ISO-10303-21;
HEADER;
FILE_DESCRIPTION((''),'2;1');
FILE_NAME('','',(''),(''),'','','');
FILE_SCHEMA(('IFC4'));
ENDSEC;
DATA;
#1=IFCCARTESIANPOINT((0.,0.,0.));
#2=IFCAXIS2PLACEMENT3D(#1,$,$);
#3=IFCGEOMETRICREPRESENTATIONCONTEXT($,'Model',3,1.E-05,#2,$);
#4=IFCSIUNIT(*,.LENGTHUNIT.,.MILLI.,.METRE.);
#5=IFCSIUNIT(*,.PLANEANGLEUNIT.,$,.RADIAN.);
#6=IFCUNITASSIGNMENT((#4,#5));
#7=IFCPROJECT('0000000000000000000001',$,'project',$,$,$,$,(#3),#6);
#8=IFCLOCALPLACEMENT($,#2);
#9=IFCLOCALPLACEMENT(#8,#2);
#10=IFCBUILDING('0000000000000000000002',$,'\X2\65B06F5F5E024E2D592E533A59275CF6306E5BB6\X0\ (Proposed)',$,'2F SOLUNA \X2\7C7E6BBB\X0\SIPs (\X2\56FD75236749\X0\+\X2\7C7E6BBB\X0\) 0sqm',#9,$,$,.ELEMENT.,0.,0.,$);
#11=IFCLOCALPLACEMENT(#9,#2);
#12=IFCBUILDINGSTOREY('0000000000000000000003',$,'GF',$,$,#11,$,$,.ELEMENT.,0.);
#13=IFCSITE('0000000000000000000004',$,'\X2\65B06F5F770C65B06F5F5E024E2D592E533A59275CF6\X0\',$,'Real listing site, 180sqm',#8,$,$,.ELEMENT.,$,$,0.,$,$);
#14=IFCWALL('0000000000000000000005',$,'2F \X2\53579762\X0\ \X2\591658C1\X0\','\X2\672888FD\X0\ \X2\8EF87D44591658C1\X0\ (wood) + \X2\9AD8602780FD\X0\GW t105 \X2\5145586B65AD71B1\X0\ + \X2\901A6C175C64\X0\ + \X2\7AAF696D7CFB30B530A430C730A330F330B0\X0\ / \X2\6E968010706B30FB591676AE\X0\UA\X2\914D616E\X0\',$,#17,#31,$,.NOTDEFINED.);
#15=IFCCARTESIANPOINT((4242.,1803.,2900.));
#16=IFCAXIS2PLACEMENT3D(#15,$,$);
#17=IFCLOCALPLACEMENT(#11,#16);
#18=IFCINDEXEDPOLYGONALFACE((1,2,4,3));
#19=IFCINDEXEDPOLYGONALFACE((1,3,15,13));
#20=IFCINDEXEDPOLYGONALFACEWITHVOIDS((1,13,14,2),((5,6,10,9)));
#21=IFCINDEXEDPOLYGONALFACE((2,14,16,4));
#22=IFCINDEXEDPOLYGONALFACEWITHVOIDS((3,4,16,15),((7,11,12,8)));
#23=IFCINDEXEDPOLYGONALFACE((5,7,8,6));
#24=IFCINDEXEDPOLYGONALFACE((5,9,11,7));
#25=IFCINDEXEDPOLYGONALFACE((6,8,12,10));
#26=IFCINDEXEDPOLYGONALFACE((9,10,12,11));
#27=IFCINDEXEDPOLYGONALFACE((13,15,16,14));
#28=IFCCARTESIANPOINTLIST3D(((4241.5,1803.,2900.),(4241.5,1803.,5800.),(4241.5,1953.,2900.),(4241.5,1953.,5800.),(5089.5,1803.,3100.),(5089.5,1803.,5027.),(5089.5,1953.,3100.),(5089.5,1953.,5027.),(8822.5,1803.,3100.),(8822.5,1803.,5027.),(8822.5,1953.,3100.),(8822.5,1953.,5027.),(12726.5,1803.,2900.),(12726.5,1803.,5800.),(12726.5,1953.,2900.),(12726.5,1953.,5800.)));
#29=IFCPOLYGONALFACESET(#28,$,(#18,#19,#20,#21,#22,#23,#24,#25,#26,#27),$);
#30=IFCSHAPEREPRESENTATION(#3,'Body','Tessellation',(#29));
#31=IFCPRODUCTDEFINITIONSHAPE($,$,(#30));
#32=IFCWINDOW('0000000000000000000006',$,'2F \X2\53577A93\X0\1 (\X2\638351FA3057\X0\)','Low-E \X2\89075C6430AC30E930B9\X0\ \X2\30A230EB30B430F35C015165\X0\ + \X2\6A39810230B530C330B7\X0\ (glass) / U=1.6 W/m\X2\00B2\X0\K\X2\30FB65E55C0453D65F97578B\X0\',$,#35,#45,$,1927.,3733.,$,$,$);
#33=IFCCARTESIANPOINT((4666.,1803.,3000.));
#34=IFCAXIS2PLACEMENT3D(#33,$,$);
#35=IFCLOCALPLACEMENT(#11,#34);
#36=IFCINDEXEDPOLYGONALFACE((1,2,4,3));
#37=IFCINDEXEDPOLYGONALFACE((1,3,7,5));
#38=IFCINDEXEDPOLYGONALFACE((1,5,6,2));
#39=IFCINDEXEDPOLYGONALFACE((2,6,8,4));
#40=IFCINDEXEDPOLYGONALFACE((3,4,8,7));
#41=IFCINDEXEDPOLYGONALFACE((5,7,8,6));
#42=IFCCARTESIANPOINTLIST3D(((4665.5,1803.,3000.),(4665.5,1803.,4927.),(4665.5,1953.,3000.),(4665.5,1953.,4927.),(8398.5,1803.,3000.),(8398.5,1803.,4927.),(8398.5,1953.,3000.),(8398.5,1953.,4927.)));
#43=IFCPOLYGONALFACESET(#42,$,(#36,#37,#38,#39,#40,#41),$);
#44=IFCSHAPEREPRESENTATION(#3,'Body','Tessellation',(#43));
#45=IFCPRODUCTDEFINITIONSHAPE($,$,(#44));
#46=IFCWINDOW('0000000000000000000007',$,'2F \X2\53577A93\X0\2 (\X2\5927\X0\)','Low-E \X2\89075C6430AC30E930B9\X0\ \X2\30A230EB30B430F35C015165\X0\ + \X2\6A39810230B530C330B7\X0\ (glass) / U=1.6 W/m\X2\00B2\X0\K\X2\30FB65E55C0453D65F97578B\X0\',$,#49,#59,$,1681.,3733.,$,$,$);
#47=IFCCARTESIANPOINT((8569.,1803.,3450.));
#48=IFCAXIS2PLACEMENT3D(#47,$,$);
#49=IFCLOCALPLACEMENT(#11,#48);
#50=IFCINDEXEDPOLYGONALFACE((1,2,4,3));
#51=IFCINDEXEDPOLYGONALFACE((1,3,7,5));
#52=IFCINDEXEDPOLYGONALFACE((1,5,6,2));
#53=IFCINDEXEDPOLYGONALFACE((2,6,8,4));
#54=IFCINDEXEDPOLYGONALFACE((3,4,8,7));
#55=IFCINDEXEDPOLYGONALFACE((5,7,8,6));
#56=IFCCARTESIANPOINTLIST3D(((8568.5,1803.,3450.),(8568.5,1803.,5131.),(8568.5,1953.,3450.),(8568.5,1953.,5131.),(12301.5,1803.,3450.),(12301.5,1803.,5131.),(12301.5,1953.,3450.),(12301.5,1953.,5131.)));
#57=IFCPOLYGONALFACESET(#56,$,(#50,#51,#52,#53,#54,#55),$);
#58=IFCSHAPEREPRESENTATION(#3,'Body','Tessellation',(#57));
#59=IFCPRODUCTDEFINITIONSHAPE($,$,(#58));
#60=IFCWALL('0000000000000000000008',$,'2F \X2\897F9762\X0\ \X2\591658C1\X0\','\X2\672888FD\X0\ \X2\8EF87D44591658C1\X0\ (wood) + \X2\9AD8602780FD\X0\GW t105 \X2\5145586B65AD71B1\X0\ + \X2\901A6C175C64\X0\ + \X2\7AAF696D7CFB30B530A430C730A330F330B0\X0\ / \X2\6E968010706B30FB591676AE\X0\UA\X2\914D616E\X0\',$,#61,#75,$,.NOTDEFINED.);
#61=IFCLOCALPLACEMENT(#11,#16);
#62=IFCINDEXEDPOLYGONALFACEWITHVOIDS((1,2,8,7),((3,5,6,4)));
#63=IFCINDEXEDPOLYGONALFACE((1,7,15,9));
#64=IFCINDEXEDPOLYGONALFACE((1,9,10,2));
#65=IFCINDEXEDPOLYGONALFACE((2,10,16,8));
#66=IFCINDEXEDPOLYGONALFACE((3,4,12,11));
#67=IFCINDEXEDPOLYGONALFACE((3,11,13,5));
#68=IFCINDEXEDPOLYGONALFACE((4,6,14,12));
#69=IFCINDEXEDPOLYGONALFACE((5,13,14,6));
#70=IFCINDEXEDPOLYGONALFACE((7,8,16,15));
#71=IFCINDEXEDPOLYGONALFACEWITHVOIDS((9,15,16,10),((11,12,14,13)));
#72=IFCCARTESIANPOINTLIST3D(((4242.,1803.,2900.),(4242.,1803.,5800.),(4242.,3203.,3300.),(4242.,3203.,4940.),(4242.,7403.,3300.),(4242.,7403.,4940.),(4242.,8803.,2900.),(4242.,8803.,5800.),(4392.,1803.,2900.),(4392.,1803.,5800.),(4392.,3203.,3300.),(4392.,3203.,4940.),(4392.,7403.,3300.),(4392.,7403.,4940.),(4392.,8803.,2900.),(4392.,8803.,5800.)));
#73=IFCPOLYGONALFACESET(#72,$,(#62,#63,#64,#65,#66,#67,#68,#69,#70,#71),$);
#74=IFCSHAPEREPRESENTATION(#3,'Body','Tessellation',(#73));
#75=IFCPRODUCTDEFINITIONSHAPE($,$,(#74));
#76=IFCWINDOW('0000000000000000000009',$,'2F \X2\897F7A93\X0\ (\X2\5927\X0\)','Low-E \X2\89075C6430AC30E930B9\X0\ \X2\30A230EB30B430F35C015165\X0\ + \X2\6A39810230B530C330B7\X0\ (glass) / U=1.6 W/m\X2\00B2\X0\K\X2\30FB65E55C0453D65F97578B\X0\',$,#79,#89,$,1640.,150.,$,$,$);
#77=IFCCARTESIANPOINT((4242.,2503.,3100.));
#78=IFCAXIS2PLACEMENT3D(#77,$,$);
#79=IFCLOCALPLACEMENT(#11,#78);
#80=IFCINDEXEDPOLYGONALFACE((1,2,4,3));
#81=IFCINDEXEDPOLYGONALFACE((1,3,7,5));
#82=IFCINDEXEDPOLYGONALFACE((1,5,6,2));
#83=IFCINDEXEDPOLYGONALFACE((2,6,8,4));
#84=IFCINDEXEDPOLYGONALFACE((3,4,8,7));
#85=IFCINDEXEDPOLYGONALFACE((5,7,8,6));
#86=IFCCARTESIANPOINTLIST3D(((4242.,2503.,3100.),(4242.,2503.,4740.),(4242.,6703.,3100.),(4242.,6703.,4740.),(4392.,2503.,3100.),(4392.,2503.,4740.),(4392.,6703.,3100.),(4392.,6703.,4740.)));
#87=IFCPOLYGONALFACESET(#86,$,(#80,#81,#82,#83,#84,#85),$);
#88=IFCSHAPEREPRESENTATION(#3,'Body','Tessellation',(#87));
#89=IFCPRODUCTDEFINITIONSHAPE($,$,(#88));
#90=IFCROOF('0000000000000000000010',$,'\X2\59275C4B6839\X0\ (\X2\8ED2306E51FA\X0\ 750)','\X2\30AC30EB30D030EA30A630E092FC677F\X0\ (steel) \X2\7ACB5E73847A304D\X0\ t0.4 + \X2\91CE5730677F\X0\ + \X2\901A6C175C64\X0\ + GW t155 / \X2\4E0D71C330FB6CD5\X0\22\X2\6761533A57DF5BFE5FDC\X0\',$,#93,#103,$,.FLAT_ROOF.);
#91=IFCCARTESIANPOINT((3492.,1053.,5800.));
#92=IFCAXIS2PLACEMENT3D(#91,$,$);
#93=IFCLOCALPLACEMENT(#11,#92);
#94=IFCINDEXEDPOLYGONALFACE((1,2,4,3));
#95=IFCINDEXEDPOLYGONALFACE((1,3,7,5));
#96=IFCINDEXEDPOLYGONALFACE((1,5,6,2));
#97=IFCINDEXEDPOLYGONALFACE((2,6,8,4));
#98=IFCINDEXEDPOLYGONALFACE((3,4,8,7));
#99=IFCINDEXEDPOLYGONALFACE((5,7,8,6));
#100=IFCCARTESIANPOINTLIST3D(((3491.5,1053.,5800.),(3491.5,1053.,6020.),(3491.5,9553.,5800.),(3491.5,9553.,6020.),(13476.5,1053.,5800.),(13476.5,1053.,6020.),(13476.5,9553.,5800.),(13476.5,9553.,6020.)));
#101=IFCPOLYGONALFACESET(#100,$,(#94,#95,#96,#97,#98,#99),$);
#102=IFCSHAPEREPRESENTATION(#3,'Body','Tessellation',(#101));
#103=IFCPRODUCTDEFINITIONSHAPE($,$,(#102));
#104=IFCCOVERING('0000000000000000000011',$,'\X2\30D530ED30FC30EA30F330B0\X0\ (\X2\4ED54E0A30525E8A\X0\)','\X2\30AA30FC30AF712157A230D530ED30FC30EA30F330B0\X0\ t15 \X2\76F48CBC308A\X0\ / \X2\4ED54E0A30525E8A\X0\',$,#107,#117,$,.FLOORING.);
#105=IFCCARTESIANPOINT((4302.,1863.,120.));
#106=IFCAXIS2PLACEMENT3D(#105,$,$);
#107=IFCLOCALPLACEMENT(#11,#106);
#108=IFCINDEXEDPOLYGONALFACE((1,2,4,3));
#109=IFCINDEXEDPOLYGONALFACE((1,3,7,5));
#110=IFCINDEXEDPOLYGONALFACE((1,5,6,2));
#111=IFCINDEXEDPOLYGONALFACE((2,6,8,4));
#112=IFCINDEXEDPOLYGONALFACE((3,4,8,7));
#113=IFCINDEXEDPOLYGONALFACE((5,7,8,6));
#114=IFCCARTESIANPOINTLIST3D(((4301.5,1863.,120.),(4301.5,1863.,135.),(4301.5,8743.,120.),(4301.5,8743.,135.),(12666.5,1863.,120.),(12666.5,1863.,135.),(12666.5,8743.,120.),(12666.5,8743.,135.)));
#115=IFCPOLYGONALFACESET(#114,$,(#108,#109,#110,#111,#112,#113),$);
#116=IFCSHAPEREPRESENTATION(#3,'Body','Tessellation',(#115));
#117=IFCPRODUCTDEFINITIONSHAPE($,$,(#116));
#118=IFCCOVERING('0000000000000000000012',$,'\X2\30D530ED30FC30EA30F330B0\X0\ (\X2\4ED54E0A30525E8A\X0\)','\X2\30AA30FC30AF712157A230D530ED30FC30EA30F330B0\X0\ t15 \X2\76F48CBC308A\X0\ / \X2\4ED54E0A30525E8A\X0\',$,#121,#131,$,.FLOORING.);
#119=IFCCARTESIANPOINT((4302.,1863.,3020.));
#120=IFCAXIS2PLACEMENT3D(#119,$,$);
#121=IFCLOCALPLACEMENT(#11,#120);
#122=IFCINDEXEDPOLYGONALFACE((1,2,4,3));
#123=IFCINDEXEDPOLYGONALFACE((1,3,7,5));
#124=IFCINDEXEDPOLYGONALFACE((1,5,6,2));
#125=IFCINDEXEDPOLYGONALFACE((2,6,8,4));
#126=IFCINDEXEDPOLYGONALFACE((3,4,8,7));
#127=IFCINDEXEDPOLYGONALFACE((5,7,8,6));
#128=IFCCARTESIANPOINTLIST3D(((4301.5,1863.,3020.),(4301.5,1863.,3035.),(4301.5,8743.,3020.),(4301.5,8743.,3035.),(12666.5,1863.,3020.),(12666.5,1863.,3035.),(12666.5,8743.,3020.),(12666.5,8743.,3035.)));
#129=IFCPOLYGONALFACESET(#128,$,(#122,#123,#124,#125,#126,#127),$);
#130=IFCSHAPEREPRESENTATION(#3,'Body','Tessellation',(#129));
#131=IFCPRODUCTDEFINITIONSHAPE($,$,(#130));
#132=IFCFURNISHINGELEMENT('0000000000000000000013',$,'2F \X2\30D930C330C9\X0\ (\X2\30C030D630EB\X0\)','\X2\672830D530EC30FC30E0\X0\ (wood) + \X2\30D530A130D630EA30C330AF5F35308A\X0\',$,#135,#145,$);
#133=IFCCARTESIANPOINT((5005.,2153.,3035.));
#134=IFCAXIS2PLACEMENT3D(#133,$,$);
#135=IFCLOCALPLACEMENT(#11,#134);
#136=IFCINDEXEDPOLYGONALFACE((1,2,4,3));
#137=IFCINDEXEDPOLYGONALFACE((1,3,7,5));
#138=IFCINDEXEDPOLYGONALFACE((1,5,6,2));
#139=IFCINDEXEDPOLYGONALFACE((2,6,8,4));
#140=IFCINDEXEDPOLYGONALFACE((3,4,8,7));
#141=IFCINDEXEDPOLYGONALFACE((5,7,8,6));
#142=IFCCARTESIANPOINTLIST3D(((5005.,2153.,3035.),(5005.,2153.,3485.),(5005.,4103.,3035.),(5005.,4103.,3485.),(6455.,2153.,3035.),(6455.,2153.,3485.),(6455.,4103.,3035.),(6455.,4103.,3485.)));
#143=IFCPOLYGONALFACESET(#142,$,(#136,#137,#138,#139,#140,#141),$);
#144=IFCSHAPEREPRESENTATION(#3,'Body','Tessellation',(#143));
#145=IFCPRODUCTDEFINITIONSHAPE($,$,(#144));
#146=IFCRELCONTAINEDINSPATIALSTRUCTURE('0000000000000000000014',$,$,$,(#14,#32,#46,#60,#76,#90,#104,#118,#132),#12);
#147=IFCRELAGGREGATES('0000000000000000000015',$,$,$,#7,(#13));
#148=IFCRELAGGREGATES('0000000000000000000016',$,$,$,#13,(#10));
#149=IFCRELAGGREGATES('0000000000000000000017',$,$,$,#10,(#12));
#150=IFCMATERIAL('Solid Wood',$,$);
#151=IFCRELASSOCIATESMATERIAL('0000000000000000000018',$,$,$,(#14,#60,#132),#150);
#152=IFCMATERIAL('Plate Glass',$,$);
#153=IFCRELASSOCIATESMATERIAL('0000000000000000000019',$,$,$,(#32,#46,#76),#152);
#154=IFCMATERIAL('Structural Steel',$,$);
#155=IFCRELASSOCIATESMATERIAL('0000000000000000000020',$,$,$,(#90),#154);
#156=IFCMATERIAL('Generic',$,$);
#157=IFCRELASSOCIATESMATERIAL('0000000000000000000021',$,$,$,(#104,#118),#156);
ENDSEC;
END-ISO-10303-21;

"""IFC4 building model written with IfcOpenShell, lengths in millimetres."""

from ifc_helpers import new_model, si_unit, frame, frame_2d, origin, place, context, project, spatial, rectangle, extrude, material, element, fill, save


model = new_model("IFC4")

# Units and contexts
model_context = context("Model", 3, precision=1e-05, world=origin())
ifc_project = project(units=[si_unit("LENGTHUNIT", "METRE", prefix="MILLI"), si_unit("PLANEANGLEUNIT", "RADIAN")], contexts=[model_context])

# Site, building, storey
site_placement = place(None, origin())
site = spatial("IfcSite", under=ifc_project, at=site_placement, Name="新潟県新潟市中央区大島", ObjectType="Real listing site, 180sqm", CompositionType="ELEMENT", RefElevation=0.0)
building_placement = place(site_placement, origin())
building = spatial("IfcBuilding", under=site, at=building_placement, Name="新潟市中央区大島の家 (Proposed)", ObjectType="2F SOLUNA 籾殻SIPs (国産杉+籾殻) 0sqm", CompositionType="ELEMENT", ElevationOfRefHeight=0.0, ElevationOfTerrain=0.0)
storey_placement = place(building_placement, origin())
storey = spatial("IfcBuildingStorey", under=building, at=storey_placement, Name="GF", CompositionType="ELEMENT", Elevation=0.0)

# Shared definitions
ifc_material_1 = material(Name="Solid Wood")

# Shared definitions
ifc_material_2 = material(Name="Plate Glass")

# Wall, openings, windows
wall_1_placement = place(storey_placement, frame((4242.0, 1803.0, 2900.0)))
wall_1 = element("IfcWall", 1, at=wall_1_placement, inside=storey, material=ifc_material_1, Name="2F 南面 外壁", Description="木製 軸組外壁 (wood) + 高性能GW t105 充填断熱 + 通気層 + 窯業系サイディング / 準耐火・外皮UA配慮", PredefinedType="NOTDEFINED", context=model_context, shape_type="SweptSolid", body=[
    extrude(rectangle(XDim=8485.0, YDim=150.0, at=frame_2d((4242.0, 75.0))), frame((4242.0, 1803.0, 2900.0)), (0.0, 0.0, 1.0), 2900.0),
])
opening_1_placement = place(storey_placement, frame((4666.0, 1803.0, 3000.0)))
opening_1 = element("IfcOpeningElement", 2, at=opening_1_placement, cuts=wall_1, PredefinedType="NOTDEFINED", context=model_context, shape_type="SweptSolid", body=[
    extrude(rectangle(XDim=3733.0, YDim=150.0, at=frame_2d((1866.0, 75.0))), frame((4666.0, 1803.0, 3000.0)), (0.0, 0.0, 1.0), 1927.0),
])
opening_2_placement = place(storey_placement, frame((8569.0, 1803.0, 3450.0)))
opening_2 = element("IfcOpeningElement", 3, at=opening_2_placement, cuts=wall_1, PredefinedType="NOTDEFINED", context=model_context, shape_type="SweptSolid", body=[
    extrude(rectangle(XDim=3733.0, YDim=150.0, at=frame_2d((1866.0, 75.0))), frame((8569.0, 1803.0, 3450.0)), (0.0, 0.0, 1.0), 1681.0),
])
window_1_placement = place(storey_placement, frame((4666.0, 1803.0, 3000.0)))
window_1 = element("IfcWindow", 4, at=window_1_placement, inside=storey, material=ifc_material_2, Name="2F 南窓1 (掃出し)", Description="Low-E 複層ガラス アルゴン封入 + 樹脂サッシ (glass) / U=1.6 W/m²K・日射取得型", OverallHeight=1927.0, OverallWidth=3733.0, context=model_context, shape_type="SweptSolid", body=[
    extrude(rectangle(XDim=3733.0, YDim=150.0, at=frame_2d((1866.0, 75.0))), frame((4666.0, 1803.0, 3000.0)), (0.0, 0.0, 1.0), 1927.0),
])
fill(opening_1, window_1)
window_2_placement = place(storey_placement, frame((8569.0, 1803.0, 3450.0)))
window_2 = element("IfcWindow", 5, at=window_2_placement, inside=storey, material=ifc_material_2, Name="2F 南窓2 (大)", Description="Low-E 複層ガラス アルゴン封入 + 樹脂サッシ (glass) / U=1.6 W/m²K・日射取得型", OverallHeight=1681.0, OverallWidth=3733.0, context=model_context, shape_type="SweptSolid", body=[
    extrude(rectangle(XDim=3733.0, YDim=150.0, at=frame_2d((1866.0, 75.0))), frame((8569.0, 1803.0, 3450.0)), (0.0, 0.0, 1.0), 1681.0),
])
fill(opening_2, window_2)

# Wall, opening, window
wall_2_placement = place(storey_placement, frame((4242.0, 1803.0, 2900.0)))
wall_2 = element("IfcWall", 6, at=wall_2_placement, inside=storey, material=ifc_material_1, Name="2F 西面 外壁", Description="木製 軸組外壁 (wood) + 高性能GW t105 充填断熱 + 通気層 + 窯業系サイディング / 準耐火・外皮UA配慮", PredefinedType="NOTDEFINED", context=model_context, shape_type="SweptSolid", body=[
    extrude(rectangle(XDim=150.0, YDim=7000.0, at=frame_2d((75.0, 3500.0))), frame((4242.0, 1803.0, 2900.0)), (0.0, 0.0, 1.0), 2900.0),
])
opening_3_placement = place(storey_placement, frame((4242.0, 2503.0, 3100.0)))
opening_3 = element("IfcOpeningElement", 7, at=opening_3_placement, cuts=wall_2, PredefinedType="NOTDEFINED", context=model_context, shape_type="SweptSolid", body=[
    extrude(rectangle(XDim=150.0, YDim=4200.0, at=frame_2d((75.0, 2100.0))), frame((4242.0, 2503.0, 3100.0)), (0.0, 0.0, 1.0), 1640.0),
])
window_3_placement = place(storey_placement, frame((4242.0, 2503.0, 3100.0)))
window_3 = element("IfcWindow", 8, at=window_3_placement, inside=storey, material=ifc_material_2, Name="2F 西窓 (大)", Description="Low-E 複層ガラス アルゴン封入 + 樹脂サッシ (glass) / U=1.6 W/m²K・日射取得型", OverallHeight=1640.0, OverallWidth=150.0, context=model_context, shape_type="SweptSolid", body=[
    extrude(rectangle(XDim=150.0, YDim=4200.0, at=frame_2d((75.0, 2100.0))), frame((4242.0, 2503.0, 3100.0)), (0.0, 0.0, 1.0), 1640.0),
])
fill(opening_3, window_3)

# Roof
ifc_material_3 = material(Name="Structural Steel")
roof_placement = place(storey_placement, frame((3492.0, 1053.0, 5800.0)))
element("IfcRoof", 9, at=roof_placement, inside=storey, material=ifc_material_3, Name="大屋根 (軒の出 750)", Description="ガルバリウム鋼板 (steel) 立平葺き t0.4 + 野地板 + 通気層 + GW t155 / 不燃・法22条区域対応", PredefinedType="FLAT_ROOF", context=model_context, shape_type="SweptSolid", body=[
    extrude(rectangle(XDim=9985.0, YDim=8500.0, at=frame_2d((4992.0, 4250.0))), frame((3492.0, 1053.0, 5800.0)), (0.0, 0.0, 1.0), 220.0),
])

# Coverings
ifc_material_4 = material(Name="Generic")
covering_1_placement = place(storey_placement, frame((4302.0, 1863.0, 120.0)))
element("IfcCovering", 10, at=covering_1_placement, inside=storey, material=ifc_material_4, Name="フローリング (仕上げ床)", Description="オーク無垢フローリング t15 直貼り / 仕上げ床", PredefinedType="FLOORING", context=model_context, shape_type="SweptSolid", body=[
    extrude(rectangle(XDim=8365.0, YDim=6880.0, at=frame_2d((4182.0, 3440.0))), frame((4302.0, 1863.0, 120.0)), (0.0, 0.0, 1.0), 15.0),
])
covering_2_placement = place(storey_placement, frame((4302.0, 1863.0, 3020.0)))
element("IfcCovering", 11, at=covering_2_placement, inside=storey, material=ifc_material_4, Name="フローリング (仕上げ床)", Description="オーク無垢フローリング t15 直貼り / 仕上げ床", PredefinedType="FLOORING", context=model_context, shape_type="SweptSolid", body=[
    extrude(rectangle(XDim=8365.0, YDim=6880.0, at=frame_2d((4182.0, 3440.0))), frame((4302.0, 1863.0, 3020.0)), (0.0, 0.0, 1.0), 15.0),
])

# Furnishing element
furnishing_placement = place(storey_placement, frame((5005.0, 2153.0, 3035.0)))
element("IfcFurnishingElement", 12, at=furnishing_placement, inside=storey, material=ifc_material_1, Name="2F ベッド (ダブル)", Description="木フレーム (wood) + ファブリック張り", context=model_context, shape_type="SweptSolid", body=[
    extrude(rectangle(XDim=1450.0, YDim=1950.0, at=frame_2d((725.0, 975.0))), frame((5005.0, 2153.0, 3035.0)), (0.0, 0.0, 1.0), 450.0),
])

save(model, "model.ifc")
